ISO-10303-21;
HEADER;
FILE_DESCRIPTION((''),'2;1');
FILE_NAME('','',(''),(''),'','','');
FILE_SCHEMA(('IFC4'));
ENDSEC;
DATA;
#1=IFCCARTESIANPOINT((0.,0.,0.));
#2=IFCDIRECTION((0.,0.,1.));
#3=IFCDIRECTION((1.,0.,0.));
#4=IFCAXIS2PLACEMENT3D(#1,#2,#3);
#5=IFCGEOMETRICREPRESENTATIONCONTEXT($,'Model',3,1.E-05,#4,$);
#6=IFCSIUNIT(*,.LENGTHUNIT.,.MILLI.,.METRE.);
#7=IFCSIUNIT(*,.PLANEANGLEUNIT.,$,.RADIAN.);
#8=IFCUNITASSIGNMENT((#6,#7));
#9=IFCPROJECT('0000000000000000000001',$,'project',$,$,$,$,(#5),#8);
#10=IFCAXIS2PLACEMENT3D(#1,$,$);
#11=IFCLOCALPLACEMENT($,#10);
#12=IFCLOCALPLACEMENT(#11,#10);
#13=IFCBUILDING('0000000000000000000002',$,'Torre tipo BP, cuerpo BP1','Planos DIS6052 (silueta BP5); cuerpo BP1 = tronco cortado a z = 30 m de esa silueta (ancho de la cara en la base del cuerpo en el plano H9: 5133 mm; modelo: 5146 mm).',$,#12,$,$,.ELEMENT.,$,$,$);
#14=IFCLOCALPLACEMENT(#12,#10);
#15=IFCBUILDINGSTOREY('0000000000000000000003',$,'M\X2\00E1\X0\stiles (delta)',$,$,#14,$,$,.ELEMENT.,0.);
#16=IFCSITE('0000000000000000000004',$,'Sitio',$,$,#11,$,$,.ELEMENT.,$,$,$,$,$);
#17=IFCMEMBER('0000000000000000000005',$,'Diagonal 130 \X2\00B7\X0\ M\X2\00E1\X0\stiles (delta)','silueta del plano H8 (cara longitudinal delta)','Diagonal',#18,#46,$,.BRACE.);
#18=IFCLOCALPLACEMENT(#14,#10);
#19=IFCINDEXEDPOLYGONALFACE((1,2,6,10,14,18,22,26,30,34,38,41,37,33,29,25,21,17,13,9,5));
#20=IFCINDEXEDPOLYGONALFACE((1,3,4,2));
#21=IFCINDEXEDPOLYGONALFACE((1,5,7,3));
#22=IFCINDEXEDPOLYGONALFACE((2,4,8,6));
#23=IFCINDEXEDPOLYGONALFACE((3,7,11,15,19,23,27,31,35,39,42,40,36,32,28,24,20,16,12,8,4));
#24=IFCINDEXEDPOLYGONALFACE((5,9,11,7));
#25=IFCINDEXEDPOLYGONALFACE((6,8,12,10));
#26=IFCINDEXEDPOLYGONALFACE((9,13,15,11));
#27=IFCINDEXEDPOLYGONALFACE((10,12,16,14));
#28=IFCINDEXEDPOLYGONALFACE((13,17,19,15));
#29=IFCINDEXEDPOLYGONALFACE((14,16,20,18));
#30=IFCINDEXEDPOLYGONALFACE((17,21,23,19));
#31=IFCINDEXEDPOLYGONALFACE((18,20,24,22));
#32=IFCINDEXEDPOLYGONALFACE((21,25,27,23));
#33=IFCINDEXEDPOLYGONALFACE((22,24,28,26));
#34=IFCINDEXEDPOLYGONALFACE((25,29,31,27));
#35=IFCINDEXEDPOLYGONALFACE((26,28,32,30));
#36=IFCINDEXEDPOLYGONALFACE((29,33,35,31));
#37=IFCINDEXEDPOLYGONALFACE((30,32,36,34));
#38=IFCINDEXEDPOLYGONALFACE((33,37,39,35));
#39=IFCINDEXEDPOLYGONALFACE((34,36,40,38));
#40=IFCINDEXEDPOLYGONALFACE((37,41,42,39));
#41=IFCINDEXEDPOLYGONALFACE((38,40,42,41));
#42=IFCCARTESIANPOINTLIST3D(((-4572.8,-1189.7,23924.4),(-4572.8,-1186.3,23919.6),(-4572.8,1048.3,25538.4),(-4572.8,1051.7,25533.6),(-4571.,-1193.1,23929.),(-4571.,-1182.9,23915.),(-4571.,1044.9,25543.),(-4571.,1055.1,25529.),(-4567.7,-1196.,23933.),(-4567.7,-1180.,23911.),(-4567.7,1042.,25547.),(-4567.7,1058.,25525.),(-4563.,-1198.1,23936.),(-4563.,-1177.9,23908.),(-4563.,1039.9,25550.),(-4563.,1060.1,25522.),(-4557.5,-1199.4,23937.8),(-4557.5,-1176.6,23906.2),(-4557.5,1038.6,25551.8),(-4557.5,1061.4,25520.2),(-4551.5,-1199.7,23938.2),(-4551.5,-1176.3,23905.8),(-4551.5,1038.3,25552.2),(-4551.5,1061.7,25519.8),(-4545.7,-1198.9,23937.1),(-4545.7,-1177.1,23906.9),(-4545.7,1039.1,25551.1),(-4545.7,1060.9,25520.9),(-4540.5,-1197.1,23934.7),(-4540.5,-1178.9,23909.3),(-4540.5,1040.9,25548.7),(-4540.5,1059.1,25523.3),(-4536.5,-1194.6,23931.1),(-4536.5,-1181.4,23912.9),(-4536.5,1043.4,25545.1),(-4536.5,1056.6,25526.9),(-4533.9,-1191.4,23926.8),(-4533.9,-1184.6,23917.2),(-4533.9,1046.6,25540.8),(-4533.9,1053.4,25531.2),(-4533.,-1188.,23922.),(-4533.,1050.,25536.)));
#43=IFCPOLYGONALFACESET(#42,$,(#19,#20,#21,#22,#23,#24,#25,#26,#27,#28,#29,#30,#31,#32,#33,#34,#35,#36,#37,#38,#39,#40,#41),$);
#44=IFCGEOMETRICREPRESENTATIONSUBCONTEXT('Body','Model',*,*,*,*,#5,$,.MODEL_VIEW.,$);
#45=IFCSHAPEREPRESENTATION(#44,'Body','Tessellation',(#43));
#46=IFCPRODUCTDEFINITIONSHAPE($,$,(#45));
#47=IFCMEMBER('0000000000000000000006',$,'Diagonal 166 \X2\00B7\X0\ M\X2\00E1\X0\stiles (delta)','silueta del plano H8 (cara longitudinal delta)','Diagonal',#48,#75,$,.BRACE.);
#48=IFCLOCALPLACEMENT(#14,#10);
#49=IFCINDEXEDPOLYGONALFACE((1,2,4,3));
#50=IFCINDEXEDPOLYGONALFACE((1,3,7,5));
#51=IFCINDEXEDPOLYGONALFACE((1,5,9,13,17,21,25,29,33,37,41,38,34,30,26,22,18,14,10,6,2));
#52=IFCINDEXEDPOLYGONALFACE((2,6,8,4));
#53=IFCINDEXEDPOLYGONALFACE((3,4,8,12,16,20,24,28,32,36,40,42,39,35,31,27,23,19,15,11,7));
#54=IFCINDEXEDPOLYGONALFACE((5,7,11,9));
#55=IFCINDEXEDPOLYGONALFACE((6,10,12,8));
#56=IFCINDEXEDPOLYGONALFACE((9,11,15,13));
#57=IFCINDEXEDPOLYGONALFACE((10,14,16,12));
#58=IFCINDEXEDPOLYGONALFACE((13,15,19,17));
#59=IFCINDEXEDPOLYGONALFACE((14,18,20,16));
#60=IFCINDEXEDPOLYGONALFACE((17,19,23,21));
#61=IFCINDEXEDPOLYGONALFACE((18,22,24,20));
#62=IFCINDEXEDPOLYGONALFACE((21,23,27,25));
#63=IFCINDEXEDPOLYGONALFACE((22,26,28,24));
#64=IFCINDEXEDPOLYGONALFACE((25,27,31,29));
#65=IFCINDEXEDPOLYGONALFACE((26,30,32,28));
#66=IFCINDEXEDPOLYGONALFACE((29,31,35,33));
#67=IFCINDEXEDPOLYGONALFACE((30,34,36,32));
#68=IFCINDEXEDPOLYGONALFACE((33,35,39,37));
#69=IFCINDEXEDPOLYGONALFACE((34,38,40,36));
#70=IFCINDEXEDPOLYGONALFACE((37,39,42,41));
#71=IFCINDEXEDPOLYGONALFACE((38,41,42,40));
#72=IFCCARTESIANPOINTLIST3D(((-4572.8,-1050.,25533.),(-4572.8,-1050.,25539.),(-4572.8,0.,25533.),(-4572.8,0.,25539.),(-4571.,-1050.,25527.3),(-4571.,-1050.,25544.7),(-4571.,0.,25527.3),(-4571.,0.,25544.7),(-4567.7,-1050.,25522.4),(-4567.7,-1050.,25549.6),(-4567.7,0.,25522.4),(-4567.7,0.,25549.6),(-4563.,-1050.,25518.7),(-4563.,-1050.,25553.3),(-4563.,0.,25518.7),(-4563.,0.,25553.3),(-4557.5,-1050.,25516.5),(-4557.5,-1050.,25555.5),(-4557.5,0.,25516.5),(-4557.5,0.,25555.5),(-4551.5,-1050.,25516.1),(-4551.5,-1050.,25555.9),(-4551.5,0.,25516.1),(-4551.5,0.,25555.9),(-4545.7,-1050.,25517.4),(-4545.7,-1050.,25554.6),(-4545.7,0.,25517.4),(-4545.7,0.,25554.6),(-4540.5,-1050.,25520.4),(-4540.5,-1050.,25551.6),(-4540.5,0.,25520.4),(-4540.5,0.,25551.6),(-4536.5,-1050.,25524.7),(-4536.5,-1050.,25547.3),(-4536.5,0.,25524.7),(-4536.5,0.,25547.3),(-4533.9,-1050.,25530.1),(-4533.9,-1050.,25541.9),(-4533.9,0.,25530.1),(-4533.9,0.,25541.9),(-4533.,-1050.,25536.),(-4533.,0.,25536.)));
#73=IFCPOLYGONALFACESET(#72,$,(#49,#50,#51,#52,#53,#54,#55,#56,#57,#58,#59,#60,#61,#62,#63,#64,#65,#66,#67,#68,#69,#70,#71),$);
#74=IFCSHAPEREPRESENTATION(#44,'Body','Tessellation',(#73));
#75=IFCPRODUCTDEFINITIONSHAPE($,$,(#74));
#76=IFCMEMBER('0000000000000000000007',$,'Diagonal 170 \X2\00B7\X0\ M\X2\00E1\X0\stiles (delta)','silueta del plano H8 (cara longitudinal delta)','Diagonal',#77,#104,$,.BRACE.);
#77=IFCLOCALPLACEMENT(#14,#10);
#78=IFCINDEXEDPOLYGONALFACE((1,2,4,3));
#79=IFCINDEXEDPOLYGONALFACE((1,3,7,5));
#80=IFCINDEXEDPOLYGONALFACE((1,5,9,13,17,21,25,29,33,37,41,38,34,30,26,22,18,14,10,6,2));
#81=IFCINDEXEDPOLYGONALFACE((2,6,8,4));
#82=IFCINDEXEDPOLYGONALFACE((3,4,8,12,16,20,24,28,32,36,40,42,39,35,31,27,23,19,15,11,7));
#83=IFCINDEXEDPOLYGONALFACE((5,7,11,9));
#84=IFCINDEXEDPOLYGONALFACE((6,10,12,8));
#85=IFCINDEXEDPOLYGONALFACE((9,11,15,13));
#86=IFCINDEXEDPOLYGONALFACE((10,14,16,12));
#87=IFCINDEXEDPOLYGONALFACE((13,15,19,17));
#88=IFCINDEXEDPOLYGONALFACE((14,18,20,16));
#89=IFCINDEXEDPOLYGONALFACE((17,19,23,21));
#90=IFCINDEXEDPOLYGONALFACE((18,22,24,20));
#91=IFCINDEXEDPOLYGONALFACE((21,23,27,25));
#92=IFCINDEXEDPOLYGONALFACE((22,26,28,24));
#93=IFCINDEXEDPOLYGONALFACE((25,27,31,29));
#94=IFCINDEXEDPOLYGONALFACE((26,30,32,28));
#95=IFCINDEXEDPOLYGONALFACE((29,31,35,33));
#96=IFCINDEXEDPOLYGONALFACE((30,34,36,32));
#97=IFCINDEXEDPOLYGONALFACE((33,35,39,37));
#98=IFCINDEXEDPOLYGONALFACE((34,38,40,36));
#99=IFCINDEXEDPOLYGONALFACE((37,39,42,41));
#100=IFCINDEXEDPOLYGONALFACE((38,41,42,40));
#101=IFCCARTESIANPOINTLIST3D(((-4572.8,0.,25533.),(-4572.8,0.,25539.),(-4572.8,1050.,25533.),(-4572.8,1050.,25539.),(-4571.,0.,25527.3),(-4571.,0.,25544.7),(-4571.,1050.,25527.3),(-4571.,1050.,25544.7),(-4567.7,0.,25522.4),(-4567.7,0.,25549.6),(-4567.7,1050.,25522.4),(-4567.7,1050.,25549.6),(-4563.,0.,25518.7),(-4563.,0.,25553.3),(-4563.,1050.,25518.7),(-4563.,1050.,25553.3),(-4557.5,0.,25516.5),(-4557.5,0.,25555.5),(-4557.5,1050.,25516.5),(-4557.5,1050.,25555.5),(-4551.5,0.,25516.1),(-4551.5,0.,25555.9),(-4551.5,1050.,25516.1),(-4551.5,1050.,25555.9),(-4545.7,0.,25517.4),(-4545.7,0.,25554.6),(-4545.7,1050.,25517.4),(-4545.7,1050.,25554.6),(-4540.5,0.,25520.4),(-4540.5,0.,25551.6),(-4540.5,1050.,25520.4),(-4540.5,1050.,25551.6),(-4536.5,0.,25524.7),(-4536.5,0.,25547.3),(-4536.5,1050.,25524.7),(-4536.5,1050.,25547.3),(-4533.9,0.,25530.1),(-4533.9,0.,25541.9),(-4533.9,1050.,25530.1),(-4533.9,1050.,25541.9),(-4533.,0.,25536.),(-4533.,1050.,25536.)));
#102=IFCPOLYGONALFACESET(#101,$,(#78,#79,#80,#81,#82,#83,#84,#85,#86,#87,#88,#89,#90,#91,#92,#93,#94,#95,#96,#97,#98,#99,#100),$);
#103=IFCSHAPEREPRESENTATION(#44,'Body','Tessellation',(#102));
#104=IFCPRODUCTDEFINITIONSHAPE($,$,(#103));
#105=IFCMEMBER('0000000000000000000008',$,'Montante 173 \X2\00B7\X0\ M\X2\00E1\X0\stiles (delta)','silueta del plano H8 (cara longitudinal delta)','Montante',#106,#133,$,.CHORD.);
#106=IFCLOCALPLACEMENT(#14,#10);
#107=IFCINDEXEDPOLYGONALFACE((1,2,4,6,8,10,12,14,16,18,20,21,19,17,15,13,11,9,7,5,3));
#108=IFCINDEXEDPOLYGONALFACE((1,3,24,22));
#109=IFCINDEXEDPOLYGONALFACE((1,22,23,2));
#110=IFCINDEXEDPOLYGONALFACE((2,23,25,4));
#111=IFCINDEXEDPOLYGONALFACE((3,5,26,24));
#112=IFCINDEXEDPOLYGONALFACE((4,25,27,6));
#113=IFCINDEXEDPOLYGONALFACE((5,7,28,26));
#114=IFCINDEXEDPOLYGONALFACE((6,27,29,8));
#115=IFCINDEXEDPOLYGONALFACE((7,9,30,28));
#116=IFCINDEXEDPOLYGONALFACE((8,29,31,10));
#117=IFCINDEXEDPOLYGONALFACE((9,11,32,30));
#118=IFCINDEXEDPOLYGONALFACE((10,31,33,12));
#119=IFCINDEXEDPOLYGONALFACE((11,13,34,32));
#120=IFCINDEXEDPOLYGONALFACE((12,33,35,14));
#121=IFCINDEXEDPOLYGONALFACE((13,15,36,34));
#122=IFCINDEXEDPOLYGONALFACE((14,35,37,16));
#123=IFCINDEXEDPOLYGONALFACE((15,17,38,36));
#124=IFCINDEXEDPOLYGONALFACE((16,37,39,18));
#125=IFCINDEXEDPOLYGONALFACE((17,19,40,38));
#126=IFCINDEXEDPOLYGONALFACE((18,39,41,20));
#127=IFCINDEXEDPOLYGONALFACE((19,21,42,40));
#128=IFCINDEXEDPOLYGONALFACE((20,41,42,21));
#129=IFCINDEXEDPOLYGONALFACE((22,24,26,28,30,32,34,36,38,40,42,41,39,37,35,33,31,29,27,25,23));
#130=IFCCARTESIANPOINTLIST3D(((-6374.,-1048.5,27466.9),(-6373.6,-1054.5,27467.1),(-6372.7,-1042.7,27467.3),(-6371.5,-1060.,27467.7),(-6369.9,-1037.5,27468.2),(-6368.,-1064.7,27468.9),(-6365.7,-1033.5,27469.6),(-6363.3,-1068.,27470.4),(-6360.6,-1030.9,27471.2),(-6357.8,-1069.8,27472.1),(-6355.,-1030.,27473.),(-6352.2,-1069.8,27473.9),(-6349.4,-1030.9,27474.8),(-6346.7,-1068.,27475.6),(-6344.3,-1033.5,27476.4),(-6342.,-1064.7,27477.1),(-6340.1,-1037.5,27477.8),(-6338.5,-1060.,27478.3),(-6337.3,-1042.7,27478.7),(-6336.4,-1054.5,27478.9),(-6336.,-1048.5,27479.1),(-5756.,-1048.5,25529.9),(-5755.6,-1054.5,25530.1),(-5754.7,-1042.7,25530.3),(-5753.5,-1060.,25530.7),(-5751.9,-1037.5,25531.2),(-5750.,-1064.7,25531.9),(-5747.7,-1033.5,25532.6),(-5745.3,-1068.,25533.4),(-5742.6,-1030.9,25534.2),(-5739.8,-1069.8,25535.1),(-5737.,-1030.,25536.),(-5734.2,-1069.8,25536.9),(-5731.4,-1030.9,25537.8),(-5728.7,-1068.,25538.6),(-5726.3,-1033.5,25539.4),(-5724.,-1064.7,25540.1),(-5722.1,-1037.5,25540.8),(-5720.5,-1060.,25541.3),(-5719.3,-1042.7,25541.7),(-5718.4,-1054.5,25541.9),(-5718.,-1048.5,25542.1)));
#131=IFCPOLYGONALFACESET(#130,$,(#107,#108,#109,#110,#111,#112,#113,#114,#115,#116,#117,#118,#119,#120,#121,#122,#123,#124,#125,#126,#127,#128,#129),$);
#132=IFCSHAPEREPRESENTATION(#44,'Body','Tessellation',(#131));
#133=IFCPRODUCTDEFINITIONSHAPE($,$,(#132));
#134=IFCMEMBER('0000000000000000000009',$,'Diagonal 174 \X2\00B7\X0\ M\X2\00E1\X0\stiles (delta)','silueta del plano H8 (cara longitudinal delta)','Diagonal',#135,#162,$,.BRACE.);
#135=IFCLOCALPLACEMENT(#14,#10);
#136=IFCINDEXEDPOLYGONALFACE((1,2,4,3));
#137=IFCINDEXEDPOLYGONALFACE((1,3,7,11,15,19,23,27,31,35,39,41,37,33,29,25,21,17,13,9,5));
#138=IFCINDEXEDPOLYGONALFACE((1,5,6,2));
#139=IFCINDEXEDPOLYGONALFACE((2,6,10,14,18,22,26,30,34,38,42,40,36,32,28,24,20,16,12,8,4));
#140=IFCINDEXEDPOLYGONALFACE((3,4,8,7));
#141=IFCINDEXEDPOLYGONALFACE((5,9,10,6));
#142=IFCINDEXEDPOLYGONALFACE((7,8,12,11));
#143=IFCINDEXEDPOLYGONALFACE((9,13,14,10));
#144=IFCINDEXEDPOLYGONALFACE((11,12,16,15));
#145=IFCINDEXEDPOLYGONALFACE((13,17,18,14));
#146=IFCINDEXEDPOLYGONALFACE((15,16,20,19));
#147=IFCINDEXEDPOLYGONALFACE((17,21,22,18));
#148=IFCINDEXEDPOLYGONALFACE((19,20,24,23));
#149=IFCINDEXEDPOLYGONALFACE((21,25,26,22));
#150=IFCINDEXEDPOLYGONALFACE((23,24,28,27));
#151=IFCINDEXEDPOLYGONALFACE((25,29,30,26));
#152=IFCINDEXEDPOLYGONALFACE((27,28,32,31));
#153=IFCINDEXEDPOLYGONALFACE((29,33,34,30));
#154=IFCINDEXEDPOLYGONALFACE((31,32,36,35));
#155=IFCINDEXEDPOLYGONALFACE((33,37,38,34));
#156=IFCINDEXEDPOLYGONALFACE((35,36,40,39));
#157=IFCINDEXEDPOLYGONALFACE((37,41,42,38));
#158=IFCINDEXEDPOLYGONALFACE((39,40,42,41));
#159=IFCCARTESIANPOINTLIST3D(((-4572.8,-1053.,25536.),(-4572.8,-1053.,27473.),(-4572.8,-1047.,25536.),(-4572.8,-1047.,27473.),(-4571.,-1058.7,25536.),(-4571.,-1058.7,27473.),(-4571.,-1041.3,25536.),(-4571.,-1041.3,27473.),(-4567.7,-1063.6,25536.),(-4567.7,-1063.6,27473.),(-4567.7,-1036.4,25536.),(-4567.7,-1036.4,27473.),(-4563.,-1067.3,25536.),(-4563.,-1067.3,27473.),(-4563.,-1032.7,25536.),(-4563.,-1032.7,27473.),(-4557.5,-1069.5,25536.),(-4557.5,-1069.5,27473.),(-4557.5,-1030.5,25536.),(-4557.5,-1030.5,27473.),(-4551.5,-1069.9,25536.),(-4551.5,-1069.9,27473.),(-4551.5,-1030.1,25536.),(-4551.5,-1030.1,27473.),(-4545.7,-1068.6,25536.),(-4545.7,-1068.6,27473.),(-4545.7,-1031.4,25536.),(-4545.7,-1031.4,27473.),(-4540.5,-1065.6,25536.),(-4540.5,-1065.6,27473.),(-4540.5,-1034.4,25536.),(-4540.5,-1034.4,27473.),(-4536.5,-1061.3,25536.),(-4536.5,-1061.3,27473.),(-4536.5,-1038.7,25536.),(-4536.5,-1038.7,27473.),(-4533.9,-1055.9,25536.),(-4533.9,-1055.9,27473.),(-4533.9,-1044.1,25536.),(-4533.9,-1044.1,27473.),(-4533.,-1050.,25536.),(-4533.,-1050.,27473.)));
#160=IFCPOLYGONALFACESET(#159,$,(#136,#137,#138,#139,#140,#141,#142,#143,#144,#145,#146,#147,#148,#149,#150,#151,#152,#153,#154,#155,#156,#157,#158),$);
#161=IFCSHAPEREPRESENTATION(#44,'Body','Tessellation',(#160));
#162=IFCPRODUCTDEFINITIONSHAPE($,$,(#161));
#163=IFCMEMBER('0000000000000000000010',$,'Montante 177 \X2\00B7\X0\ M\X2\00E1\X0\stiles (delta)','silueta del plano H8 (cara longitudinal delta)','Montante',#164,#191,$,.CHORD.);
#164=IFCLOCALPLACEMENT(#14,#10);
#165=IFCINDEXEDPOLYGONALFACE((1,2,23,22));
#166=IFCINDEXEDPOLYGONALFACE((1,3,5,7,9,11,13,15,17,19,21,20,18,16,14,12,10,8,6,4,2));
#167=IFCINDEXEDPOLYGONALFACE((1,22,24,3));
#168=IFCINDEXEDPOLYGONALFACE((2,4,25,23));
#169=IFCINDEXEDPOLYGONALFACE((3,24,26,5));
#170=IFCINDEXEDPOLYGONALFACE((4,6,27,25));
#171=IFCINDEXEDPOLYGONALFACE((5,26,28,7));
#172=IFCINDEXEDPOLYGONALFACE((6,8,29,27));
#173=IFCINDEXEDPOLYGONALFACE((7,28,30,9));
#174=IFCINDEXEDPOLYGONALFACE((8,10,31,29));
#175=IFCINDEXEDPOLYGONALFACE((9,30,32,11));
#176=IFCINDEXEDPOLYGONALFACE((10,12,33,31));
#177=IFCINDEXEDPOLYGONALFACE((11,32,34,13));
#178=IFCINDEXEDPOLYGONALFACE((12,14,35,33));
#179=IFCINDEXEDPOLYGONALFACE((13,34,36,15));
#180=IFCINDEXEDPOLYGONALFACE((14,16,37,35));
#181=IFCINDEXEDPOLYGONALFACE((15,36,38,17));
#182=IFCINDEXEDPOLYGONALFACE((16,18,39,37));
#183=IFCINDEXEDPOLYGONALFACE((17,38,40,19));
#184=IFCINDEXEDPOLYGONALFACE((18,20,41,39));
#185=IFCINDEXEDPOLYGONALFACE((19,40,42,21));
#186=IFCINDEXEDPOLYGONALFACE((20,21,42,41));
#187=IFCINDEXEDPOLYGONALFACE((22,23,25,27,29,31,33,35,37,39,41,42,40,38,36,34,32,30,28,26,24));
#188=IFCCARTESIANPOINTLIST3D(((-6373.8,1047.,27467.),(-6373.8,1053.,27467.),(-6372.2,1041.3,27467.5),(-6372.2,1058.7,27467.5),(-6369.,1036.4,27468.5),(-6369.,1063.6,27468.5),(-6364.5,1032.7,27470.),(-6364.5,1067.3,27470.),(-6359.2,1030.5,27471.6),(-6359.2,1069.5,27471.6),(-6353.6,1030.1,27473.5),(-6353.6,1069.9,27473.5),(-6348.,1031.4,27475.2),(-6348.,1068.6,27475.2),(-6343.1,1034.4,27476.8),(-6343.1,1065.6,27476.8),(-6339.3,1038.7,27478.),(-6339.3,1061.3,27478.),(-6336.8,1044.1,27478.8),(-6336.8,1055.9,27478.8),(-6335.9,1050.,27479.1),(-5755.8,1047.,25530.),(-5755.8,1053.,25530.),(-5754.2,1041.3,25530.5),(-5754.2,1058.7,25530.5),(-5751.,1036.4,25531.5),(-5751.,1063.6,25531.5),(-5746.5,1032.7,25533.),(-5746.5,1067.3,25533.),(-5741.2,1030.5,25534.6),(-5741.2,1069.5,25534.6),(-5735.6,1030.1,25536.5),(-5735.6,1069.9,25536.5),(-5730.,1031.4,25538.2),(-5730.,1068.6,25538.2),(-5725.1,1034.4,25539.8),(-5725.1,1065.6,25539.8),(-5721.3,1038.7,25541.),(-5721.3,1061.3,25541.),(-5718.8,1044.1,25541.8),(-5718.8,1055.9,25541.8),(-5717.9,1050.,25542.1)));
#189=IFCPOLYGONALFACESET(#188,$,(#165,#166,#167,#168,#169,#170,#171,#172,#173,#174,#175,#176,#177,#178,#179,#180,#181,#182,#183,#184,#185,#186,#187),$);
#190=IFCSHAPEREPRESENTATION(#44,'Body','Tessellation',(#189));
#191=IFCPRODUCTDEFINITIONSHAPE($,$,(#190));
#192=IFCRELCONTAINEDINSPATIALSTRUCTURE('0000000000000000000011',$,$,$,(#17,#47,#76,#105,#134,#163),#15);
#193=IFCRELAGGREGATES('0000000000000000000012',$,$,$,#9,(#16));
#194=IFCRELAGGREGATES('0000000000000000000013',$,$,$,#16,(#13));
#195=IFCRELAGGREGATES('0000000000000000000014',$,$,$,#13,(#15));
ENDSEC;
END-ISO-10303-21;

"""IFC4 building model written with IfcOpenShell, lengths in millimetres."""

from ifc_helpers import new_model, si_unit, frame, origin, origin_with_axes, place, context, subcontext, project, spatial, circle, extrude, element, save


model = new_model("IFC4")

# Units and contexts
model_context = context("Model", 3, precision=1e-05, world=origin_with_axes())
body_context = subcontext(model_context, "Body", "Model", "MODEL_VIEW")
ifc_project = project(units=[si_unit("LENGTHUNIT", "METRE", prefix="MILLI"), si_unit("PLANEANGLEUNIT", "RADIAN")], contexts=[model_context])

# Site, building, storey
site_placement = place(None, origin())
site = spatial("IfcSite", under=ifc_project, at=site_placement, Name="Sitio", CompositionType="ELEMENT")
building_placement = place(site_placement, origin())
building = spatial("IfcBuilding", under=site, at=building_placement, Name="Torre tipo BP, cuerpo BP1", Description="Planos DIS6052 (silueta BP5); cuerpo BP1 = tronco cortado a z = 30 m de esa silueta (ancho de la cara en la base del cuerpo en el plano H9: 5133 mm; modelo: 5146 mm).", CompositionType="ELEMENT")
storey_placement = place(building_placement, origin())
storey = spatial("IfcBuildingStorey", under=building, at=storey_placement, Name="Mástiles (delta)", CompositionType="ELEMENT", Elevation=0.0)

# Members
member_1_placement = place(storey_placement, frame((-4553.0, 1050.0, 25536.0), z_axis=(0.0, -0.81108, -0.584935), x_axis=(1.0, 0.0, 0.0)))
element("IfcMember", 1, at=member_1_placement, inside=storey, Name="Diagonal 130 · Mástiles (delta)", Description="silueta del plano H8 (cara longitudinal delta)", ObjectType="Diagonal", PredefinedType="BRACE", context=body_context, shape_type="SweptSolid", body=[
    extrude(circle(Radius=20.0), None, (0.0, 0.0, 1.0), 2759.3),
])
for number, where, z_axis, x_axis, name in (
    (2, (-4553.0, -1050.0, 25536.0), (0.0, 1.0, 0.0), (1.0, 0.0, 0.0), "Diagonal 166 · Mástiles (delta)"),
    (3, (-4553.0, 1050.0, 25536.0), (0.0, -1.0, 0.0), (1.0, 0.0, 0.0), "Diagonal 170 · Mástiles (delta)"),
):
    element("IfcMember", number, at=place(storey_placement, frame(where, z_axis=z_axis, x_axis=x_axis)), inside=storey, Name=name, Description="silueta del plano H8 (cara longitudinal delta)", ObjectType="Diagonal", PredefinedType="BRACE", context=body_context, shape_type="SweptSolid", body=[
        extrude(circle(Radius=20.0), None, (0.0, 0.0, 1.0), 1050.0),
    ])
member_2_placement = place(storey_placement, frame((-6355.0, -1050.0, 27473.0), z_axis=(0.303955, 0.0, -0.952686), x_axis=(0.0, 1.0, 0.0)))
element("IfcMember", 4, at=member_2_placement, inside=storey, Name="Montante 173 · Mástiles (delta)", Description="silueta del plano H8 (cara longitudinal delta)", ObjectType="Montante", PredefinedType="CHORD", context=body_context, shape_type="SweptSolid", body=[
    extrude(circle(Radius=20.0), None, (0.0, 0.0, 1.0), 2033.2),
])
member_3_placement = place(storey_placement, frame((-4553.0, -1050.0, 27473.0), z_axis=(0.0, 0.0, -1.0), x_axis=(1.0, 0.0, 0.0)))
element("IfcMember", 5, at=member_3_placement, inside=storey, Name="Diagonal 174 · Mástiles (delta)", Description="silueta del plano H8 (cara longitudinal delta)", ObjectType="Diagonal", PredefinedType="BRACE", context=body_context, shape_type="SweptSolid", body=[
    extrude(circle(Radius=20.0), None, (0.0, 0.0, 1.0), 1937.0),
])
member_4_placement = place(storey_placement, frame((-6355.0, 1050.0, 27473.0), z_axis=(0.303955, 0.0, -0.952686), x_axis=(0.952686, 0.0, 0.303955)))
element("IfcMember", 6, at=member_4_placement, inside=storey, Name="Montante 177 · Mástiles (delta)", Description="silueta del plano H8 (cara longitudinal delta)", ObjectType="Montante", PredefinedType="CHORD", context=body_context, shape_type="SweptSolid", body=[
    extrude(circle(Radius=20.0), None, (0.0, 0.0, 1.0), 2033.2),
])

save(model, "model.ifc")
